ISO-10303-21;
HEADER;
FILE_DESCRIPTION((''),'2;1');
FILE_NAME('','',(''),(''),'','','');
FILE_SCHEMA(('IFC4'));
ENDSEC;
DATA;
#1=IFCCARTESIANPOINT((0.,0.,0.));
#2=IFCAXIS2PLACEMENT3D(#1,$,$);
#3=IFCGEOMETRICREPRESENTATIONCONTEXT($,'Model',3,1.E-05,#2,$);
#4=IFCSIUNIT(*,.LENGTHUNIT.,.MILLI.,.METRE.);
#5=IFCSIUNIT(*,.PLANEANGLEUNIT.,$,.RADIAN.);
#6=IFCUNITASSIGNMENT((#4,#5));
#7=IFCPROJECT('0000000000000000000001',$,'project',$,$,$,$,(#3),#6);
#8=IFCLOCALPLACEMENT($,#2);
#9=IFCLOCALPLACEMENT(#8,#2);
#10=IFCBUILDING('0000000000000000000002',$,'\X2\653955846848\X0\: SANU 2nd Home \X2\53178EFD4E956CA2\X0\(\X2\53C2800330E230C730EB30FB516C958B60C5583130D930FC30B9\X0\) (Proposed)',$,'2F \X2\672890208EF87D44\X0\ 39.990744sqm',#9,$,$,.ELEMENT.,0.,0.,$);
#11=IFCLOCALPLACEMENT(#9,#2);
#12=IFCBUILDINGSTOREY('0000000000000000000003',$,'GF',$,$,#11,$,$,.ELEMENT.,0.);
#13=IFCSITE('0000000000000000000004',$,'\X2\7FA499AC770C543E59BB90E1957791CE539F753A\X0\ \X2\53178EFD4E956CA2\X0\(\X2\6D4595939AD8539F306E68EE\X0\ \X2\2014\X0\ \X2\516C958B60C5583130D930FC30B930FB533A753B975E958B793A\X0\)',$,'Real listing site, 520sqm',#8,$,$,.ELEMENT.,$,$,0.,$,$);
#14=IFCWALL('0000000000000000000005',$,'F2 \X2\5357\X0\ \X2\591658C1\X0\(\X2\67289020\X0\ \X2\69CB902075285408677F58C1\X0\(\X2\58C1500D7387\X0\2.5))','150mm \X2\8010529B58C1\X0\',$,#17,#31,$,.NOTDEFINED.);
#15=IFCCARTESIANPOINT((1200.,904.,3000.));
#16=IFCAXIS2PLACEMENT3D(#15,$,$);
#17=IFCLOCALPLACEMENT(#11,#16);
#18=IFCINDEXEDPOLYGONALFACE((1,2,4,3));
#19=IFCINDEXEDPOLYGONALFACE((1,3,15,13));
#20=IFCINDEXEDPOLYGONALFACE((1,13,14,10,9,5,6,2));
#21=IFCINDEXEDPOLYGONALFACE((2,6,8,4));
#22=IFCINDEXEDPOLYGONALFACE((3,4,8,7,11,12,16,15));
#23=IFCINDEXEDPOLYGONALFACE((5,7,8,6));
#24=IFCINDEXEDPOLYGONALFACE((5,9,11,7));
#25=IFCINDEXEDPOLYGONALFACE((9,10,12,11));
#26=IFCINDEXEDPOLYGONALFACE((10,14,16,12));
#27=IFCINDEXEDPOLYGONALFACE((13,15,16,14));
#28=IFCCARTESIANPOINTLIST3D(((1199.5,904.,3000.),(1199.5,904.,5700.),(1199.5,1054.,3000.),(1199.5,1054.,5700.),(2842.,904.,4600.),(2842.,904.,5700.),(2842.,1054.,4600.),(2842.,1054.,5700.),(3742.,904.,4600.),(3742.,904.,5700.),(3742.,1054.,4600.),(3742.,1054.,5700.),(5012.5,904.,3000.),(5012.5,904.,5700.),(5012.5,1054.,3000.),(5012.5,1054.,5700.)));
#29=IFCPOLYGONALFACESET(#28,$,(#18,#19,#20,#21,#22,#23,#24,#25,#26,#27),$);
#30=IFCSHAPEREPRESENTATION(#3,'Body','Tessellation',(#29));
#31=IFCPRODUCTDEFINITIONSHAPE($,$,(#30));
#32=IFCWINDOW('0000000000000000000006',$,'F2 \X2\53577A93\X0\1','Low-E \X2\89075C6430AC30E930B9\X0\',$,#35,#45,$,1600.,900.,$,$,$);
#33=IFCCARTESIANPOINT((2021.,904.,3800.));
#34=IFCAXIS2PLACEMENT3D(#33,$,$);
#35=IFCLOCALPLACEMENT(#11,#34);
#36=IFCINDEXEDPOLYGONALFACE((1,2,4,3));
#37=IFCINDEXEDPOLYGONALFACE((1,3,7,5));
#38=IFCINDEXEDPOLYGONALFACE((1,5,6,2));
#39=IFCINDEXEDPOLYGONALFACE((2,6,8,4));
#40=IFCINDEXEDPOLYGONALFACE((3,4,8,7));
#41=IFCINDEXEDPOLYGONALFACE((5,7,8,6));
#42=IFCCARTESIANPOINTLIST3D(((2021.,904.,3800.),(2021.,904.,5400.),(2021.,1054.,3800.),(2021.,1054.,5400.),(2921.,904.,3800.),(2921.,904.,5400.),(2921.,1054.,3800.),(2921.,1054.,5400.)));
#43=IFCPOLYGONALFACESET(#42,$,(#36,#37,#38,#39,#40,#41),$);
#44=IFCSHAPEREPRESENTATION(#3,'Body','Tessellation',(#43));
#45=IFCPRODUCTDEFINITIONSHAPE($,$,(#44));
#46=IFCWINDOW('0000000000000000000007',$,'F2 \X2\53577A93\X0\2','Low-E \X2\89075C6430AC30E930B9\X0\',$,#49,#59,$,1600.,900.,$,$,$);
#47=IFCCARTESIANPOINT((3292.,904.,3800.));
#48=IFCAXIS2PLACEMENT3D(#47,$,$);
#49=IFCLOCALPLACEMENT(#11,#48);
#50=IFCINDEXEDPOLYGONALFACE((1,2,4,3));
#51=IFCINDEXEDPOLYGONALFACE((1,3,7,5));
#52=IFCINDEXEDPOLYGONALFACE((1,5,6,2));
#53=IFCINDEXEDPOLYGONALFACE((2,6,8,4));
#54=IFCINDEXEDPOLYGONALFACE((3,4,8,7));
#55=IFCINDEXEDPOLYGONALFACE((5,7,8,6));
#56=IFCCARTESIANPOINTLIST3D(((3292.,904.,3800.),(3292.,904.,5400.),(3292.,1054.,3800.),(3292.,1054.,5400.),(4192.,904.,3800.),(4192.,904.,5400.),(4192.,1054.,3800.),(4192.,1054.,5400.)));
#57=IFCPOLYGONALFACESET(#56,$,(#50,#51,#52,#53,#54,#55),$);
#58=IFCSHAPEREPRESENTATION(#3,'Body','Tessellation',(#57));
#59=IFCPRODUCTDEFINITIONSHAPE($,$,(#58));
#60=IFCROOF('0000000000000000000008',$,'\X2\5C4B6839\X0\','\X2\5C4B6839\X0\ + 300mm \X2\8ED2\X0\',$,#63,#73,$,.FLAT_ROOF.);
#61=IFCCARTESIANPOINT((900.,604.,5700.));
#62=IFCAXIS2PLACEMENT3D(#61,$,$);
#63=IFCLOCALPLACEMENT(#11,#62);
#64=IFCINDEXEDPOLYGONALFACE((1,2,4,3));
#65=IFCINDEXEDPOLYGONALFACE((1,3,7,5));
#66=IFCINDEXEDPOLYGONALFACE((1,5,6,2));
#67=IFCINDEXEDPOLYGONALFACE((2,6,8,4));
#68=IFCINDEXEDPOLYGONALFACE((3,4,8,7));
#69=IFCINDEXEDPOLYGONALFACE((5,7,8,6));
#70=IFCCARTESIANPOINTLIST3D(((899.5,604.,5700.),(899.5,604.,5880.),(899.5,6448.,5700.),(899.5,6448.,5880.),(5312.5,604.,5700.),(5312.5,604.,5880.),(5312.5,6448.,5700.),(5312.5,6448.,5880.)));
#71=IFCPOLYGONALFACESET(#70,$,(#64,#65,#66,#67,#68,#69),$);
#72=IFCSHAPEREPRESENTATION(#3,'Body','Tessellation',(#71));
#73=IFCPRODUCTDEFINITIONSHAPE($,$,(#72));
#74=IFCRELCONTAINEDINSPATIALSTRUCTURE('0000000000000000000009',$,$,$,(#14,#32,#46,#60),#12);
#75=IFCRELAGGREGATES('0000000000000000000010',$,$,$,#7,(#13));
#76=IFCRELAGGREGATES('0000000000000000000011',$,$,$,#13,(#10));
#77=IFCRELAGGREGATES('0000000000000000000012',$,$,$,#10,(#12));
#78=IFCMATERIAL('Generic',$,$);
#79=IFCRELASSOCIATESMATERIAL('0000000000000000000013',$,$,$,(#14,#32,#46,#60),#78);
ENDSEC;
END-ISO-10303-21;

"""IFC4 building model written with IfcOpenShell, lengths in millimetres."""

from ifc_helpers import new_model, si_unit, frame, frame_2d, origin, place, context, project, spatial, rectangle, extrude, material, element, fill, save


model = new_model("IFC4")

# Units and contexts
model_context = context("Model", 3, precision=1e-05, world=origin())
ifc_project = project(units=[si_unit("LENGTHUNIT", "METRE", prefix="MILLI"), si_unit("PLANEANGLEUNIT", "RADIAN")], contexts=[model_context])

# Site, building, storey
site_placement = place(None, origin())
site = spatial("IfcSite", under=ifc_project, at=site_placement, Name="群馬県吾妻郡長野原町 北軽井沢(浅間高原の森 — 公開情報ベース・区画非開示)", ObjectType="Real listing site, 520sqm", CompositionType="ELEMENT", RefElevation=0.0)
building_placement = place(site_placement, origin())
building = spatial("IfcBuilding", under=site, at=building_placement, Name="改善案: SANU 2nd Home 北軽井沢(参考モデル・公開情報ベース) (Proposed)", ObjectType="2F 木造軸組 39.990744sqm", CompositionType="ELEMENT", ElevationOfRefHeight=0.0, ElevationOfTerrain=0.0)
storey_placement = place(building_placement, origin())
storey = spatial("IfcBuildingStorey", under=building, at=storey_placement, Name="GF", CompositionType="ELEMENT", Elevation=0.0)

# Shared definitions
ifc_material_1 = material(Name="Generic")

# Wall, openings, windows
wall_1_placement = place(storey_placement, frame((1200.0, 904.0, 3000.0)))
wall_1 = element("IfcWall", 1, at=wall_1_placement, inside=storey, material=ifc_material_1, Name="F2 南 外壁(木造 構造用合板壁(壁倍率2.5))", Description="150mm 耐力壁", PredefinedType="NOTDEFINED", context=model_context, shape_type="SweptSolid", body=[
    extrude(rectangle(XDim=3813.0, YDim=150.0, at=frame_2d((1906.0, 75.0))), frame((1200.0, 904.0, 3000.0)), (0.0, 0.0, 1.0), 2700.0),
])
opening_1_placement = place(storey_placement, frame((2021.0, 904.0, 3800.0)))
opening_1 = element("IfcOpeningElement", 2, at=opening_1_placement, cuts=wall_1, PredefinedType="NOTDEFINED", context=model_context, shape_type="SweptSolid", body=[
    extrude(rectangle(XDim=900.0, YDim=150.0, at=frame_2d((450.0, 75.0))), frame((2021.0, 904.0, 3800.0)), (0.0, 0.0, 1.0), 1600.0),
])
opening_2_placement = place(storey_placement, frame((3292.0, 904.0, 3800.0)))
opening_2 = element("IfcOpeningElement", 3, at=opening_2_placement, cuts=wall_1, PredefinedType="NOTDEFINED", context=model_context, shape_type="SweptSolid", body=[
    extrude(rectangle(XDim=900.0, YDim=150.0, at=frame_2d((450.0, 75.0))), frame((3292.0, 904.0, 3800.0)), (0.0, 0.0, 1.0), 1600.0),
])
window_1_placement = place(storey_placement, frame((2021.0, 904.0, 3800.0)))
window_1 = element("IfcWindow", 4, at=window_1_placement, inside=storey, material=ifc_material_1, Name="F2 南窓1", Description="Low-E 複層ガラス", OverallHeight=1600.0, OverallWidth=900.0, context=model_context, shape_type="SweptSolid", body=[
    extrude(rectangle(XDim=900.0, YDim=150.0, at=frame_2d((450.0, 75.0))), frame((2021.0, 904.0, 3800.0)), (0.0, 0.0, 1.0), 1600.0),
])
fill(opening_1, window_1)
window_2_placement = place(storey_placement, frame((3292.0, 904.0, 3800.0)))
window_2 = element("IfcWindow", 5, at=window_2_placement, inside=storey, material=ifc_material_1, Name="F2 南窓2", Description="Low-E 複層ガラス", OverallHeight=1600.0, OverallWidth=900.0, context=model_context, shape_type="SweptSolid", body=[
    extrude(rectangle(XDim=900.0, YDim=150.0, at=frame_2d((450.0, 75.0))), frame((3292.0, 904.0, 3800.0)), (0.0, 0.0, 1.0), 1600.0),
])
fill(opening_2, window_2)

# Roof
roof_placement = place(storey_placement, frame((900.0, 604.0, 5700.0)))
element("IfcRoof", 6, at=roof_placement, inside=storey, material=ifc_material_1, Name="屋根", Description="屋根 + 300mm 軒", PredefinedType="FLAT_ROOF", context=model_context, shape_type="SweptSolid", body=[
    extrude(rectangle(XDim=4413.0, YDim=5844.0, at=frame_2d((2206.0, 2922.0))), frame((900.0, 604.0, 5700.0)), (0.0, 0.0, 1.0), 180.0),
])

save(model, "model.ifc")
